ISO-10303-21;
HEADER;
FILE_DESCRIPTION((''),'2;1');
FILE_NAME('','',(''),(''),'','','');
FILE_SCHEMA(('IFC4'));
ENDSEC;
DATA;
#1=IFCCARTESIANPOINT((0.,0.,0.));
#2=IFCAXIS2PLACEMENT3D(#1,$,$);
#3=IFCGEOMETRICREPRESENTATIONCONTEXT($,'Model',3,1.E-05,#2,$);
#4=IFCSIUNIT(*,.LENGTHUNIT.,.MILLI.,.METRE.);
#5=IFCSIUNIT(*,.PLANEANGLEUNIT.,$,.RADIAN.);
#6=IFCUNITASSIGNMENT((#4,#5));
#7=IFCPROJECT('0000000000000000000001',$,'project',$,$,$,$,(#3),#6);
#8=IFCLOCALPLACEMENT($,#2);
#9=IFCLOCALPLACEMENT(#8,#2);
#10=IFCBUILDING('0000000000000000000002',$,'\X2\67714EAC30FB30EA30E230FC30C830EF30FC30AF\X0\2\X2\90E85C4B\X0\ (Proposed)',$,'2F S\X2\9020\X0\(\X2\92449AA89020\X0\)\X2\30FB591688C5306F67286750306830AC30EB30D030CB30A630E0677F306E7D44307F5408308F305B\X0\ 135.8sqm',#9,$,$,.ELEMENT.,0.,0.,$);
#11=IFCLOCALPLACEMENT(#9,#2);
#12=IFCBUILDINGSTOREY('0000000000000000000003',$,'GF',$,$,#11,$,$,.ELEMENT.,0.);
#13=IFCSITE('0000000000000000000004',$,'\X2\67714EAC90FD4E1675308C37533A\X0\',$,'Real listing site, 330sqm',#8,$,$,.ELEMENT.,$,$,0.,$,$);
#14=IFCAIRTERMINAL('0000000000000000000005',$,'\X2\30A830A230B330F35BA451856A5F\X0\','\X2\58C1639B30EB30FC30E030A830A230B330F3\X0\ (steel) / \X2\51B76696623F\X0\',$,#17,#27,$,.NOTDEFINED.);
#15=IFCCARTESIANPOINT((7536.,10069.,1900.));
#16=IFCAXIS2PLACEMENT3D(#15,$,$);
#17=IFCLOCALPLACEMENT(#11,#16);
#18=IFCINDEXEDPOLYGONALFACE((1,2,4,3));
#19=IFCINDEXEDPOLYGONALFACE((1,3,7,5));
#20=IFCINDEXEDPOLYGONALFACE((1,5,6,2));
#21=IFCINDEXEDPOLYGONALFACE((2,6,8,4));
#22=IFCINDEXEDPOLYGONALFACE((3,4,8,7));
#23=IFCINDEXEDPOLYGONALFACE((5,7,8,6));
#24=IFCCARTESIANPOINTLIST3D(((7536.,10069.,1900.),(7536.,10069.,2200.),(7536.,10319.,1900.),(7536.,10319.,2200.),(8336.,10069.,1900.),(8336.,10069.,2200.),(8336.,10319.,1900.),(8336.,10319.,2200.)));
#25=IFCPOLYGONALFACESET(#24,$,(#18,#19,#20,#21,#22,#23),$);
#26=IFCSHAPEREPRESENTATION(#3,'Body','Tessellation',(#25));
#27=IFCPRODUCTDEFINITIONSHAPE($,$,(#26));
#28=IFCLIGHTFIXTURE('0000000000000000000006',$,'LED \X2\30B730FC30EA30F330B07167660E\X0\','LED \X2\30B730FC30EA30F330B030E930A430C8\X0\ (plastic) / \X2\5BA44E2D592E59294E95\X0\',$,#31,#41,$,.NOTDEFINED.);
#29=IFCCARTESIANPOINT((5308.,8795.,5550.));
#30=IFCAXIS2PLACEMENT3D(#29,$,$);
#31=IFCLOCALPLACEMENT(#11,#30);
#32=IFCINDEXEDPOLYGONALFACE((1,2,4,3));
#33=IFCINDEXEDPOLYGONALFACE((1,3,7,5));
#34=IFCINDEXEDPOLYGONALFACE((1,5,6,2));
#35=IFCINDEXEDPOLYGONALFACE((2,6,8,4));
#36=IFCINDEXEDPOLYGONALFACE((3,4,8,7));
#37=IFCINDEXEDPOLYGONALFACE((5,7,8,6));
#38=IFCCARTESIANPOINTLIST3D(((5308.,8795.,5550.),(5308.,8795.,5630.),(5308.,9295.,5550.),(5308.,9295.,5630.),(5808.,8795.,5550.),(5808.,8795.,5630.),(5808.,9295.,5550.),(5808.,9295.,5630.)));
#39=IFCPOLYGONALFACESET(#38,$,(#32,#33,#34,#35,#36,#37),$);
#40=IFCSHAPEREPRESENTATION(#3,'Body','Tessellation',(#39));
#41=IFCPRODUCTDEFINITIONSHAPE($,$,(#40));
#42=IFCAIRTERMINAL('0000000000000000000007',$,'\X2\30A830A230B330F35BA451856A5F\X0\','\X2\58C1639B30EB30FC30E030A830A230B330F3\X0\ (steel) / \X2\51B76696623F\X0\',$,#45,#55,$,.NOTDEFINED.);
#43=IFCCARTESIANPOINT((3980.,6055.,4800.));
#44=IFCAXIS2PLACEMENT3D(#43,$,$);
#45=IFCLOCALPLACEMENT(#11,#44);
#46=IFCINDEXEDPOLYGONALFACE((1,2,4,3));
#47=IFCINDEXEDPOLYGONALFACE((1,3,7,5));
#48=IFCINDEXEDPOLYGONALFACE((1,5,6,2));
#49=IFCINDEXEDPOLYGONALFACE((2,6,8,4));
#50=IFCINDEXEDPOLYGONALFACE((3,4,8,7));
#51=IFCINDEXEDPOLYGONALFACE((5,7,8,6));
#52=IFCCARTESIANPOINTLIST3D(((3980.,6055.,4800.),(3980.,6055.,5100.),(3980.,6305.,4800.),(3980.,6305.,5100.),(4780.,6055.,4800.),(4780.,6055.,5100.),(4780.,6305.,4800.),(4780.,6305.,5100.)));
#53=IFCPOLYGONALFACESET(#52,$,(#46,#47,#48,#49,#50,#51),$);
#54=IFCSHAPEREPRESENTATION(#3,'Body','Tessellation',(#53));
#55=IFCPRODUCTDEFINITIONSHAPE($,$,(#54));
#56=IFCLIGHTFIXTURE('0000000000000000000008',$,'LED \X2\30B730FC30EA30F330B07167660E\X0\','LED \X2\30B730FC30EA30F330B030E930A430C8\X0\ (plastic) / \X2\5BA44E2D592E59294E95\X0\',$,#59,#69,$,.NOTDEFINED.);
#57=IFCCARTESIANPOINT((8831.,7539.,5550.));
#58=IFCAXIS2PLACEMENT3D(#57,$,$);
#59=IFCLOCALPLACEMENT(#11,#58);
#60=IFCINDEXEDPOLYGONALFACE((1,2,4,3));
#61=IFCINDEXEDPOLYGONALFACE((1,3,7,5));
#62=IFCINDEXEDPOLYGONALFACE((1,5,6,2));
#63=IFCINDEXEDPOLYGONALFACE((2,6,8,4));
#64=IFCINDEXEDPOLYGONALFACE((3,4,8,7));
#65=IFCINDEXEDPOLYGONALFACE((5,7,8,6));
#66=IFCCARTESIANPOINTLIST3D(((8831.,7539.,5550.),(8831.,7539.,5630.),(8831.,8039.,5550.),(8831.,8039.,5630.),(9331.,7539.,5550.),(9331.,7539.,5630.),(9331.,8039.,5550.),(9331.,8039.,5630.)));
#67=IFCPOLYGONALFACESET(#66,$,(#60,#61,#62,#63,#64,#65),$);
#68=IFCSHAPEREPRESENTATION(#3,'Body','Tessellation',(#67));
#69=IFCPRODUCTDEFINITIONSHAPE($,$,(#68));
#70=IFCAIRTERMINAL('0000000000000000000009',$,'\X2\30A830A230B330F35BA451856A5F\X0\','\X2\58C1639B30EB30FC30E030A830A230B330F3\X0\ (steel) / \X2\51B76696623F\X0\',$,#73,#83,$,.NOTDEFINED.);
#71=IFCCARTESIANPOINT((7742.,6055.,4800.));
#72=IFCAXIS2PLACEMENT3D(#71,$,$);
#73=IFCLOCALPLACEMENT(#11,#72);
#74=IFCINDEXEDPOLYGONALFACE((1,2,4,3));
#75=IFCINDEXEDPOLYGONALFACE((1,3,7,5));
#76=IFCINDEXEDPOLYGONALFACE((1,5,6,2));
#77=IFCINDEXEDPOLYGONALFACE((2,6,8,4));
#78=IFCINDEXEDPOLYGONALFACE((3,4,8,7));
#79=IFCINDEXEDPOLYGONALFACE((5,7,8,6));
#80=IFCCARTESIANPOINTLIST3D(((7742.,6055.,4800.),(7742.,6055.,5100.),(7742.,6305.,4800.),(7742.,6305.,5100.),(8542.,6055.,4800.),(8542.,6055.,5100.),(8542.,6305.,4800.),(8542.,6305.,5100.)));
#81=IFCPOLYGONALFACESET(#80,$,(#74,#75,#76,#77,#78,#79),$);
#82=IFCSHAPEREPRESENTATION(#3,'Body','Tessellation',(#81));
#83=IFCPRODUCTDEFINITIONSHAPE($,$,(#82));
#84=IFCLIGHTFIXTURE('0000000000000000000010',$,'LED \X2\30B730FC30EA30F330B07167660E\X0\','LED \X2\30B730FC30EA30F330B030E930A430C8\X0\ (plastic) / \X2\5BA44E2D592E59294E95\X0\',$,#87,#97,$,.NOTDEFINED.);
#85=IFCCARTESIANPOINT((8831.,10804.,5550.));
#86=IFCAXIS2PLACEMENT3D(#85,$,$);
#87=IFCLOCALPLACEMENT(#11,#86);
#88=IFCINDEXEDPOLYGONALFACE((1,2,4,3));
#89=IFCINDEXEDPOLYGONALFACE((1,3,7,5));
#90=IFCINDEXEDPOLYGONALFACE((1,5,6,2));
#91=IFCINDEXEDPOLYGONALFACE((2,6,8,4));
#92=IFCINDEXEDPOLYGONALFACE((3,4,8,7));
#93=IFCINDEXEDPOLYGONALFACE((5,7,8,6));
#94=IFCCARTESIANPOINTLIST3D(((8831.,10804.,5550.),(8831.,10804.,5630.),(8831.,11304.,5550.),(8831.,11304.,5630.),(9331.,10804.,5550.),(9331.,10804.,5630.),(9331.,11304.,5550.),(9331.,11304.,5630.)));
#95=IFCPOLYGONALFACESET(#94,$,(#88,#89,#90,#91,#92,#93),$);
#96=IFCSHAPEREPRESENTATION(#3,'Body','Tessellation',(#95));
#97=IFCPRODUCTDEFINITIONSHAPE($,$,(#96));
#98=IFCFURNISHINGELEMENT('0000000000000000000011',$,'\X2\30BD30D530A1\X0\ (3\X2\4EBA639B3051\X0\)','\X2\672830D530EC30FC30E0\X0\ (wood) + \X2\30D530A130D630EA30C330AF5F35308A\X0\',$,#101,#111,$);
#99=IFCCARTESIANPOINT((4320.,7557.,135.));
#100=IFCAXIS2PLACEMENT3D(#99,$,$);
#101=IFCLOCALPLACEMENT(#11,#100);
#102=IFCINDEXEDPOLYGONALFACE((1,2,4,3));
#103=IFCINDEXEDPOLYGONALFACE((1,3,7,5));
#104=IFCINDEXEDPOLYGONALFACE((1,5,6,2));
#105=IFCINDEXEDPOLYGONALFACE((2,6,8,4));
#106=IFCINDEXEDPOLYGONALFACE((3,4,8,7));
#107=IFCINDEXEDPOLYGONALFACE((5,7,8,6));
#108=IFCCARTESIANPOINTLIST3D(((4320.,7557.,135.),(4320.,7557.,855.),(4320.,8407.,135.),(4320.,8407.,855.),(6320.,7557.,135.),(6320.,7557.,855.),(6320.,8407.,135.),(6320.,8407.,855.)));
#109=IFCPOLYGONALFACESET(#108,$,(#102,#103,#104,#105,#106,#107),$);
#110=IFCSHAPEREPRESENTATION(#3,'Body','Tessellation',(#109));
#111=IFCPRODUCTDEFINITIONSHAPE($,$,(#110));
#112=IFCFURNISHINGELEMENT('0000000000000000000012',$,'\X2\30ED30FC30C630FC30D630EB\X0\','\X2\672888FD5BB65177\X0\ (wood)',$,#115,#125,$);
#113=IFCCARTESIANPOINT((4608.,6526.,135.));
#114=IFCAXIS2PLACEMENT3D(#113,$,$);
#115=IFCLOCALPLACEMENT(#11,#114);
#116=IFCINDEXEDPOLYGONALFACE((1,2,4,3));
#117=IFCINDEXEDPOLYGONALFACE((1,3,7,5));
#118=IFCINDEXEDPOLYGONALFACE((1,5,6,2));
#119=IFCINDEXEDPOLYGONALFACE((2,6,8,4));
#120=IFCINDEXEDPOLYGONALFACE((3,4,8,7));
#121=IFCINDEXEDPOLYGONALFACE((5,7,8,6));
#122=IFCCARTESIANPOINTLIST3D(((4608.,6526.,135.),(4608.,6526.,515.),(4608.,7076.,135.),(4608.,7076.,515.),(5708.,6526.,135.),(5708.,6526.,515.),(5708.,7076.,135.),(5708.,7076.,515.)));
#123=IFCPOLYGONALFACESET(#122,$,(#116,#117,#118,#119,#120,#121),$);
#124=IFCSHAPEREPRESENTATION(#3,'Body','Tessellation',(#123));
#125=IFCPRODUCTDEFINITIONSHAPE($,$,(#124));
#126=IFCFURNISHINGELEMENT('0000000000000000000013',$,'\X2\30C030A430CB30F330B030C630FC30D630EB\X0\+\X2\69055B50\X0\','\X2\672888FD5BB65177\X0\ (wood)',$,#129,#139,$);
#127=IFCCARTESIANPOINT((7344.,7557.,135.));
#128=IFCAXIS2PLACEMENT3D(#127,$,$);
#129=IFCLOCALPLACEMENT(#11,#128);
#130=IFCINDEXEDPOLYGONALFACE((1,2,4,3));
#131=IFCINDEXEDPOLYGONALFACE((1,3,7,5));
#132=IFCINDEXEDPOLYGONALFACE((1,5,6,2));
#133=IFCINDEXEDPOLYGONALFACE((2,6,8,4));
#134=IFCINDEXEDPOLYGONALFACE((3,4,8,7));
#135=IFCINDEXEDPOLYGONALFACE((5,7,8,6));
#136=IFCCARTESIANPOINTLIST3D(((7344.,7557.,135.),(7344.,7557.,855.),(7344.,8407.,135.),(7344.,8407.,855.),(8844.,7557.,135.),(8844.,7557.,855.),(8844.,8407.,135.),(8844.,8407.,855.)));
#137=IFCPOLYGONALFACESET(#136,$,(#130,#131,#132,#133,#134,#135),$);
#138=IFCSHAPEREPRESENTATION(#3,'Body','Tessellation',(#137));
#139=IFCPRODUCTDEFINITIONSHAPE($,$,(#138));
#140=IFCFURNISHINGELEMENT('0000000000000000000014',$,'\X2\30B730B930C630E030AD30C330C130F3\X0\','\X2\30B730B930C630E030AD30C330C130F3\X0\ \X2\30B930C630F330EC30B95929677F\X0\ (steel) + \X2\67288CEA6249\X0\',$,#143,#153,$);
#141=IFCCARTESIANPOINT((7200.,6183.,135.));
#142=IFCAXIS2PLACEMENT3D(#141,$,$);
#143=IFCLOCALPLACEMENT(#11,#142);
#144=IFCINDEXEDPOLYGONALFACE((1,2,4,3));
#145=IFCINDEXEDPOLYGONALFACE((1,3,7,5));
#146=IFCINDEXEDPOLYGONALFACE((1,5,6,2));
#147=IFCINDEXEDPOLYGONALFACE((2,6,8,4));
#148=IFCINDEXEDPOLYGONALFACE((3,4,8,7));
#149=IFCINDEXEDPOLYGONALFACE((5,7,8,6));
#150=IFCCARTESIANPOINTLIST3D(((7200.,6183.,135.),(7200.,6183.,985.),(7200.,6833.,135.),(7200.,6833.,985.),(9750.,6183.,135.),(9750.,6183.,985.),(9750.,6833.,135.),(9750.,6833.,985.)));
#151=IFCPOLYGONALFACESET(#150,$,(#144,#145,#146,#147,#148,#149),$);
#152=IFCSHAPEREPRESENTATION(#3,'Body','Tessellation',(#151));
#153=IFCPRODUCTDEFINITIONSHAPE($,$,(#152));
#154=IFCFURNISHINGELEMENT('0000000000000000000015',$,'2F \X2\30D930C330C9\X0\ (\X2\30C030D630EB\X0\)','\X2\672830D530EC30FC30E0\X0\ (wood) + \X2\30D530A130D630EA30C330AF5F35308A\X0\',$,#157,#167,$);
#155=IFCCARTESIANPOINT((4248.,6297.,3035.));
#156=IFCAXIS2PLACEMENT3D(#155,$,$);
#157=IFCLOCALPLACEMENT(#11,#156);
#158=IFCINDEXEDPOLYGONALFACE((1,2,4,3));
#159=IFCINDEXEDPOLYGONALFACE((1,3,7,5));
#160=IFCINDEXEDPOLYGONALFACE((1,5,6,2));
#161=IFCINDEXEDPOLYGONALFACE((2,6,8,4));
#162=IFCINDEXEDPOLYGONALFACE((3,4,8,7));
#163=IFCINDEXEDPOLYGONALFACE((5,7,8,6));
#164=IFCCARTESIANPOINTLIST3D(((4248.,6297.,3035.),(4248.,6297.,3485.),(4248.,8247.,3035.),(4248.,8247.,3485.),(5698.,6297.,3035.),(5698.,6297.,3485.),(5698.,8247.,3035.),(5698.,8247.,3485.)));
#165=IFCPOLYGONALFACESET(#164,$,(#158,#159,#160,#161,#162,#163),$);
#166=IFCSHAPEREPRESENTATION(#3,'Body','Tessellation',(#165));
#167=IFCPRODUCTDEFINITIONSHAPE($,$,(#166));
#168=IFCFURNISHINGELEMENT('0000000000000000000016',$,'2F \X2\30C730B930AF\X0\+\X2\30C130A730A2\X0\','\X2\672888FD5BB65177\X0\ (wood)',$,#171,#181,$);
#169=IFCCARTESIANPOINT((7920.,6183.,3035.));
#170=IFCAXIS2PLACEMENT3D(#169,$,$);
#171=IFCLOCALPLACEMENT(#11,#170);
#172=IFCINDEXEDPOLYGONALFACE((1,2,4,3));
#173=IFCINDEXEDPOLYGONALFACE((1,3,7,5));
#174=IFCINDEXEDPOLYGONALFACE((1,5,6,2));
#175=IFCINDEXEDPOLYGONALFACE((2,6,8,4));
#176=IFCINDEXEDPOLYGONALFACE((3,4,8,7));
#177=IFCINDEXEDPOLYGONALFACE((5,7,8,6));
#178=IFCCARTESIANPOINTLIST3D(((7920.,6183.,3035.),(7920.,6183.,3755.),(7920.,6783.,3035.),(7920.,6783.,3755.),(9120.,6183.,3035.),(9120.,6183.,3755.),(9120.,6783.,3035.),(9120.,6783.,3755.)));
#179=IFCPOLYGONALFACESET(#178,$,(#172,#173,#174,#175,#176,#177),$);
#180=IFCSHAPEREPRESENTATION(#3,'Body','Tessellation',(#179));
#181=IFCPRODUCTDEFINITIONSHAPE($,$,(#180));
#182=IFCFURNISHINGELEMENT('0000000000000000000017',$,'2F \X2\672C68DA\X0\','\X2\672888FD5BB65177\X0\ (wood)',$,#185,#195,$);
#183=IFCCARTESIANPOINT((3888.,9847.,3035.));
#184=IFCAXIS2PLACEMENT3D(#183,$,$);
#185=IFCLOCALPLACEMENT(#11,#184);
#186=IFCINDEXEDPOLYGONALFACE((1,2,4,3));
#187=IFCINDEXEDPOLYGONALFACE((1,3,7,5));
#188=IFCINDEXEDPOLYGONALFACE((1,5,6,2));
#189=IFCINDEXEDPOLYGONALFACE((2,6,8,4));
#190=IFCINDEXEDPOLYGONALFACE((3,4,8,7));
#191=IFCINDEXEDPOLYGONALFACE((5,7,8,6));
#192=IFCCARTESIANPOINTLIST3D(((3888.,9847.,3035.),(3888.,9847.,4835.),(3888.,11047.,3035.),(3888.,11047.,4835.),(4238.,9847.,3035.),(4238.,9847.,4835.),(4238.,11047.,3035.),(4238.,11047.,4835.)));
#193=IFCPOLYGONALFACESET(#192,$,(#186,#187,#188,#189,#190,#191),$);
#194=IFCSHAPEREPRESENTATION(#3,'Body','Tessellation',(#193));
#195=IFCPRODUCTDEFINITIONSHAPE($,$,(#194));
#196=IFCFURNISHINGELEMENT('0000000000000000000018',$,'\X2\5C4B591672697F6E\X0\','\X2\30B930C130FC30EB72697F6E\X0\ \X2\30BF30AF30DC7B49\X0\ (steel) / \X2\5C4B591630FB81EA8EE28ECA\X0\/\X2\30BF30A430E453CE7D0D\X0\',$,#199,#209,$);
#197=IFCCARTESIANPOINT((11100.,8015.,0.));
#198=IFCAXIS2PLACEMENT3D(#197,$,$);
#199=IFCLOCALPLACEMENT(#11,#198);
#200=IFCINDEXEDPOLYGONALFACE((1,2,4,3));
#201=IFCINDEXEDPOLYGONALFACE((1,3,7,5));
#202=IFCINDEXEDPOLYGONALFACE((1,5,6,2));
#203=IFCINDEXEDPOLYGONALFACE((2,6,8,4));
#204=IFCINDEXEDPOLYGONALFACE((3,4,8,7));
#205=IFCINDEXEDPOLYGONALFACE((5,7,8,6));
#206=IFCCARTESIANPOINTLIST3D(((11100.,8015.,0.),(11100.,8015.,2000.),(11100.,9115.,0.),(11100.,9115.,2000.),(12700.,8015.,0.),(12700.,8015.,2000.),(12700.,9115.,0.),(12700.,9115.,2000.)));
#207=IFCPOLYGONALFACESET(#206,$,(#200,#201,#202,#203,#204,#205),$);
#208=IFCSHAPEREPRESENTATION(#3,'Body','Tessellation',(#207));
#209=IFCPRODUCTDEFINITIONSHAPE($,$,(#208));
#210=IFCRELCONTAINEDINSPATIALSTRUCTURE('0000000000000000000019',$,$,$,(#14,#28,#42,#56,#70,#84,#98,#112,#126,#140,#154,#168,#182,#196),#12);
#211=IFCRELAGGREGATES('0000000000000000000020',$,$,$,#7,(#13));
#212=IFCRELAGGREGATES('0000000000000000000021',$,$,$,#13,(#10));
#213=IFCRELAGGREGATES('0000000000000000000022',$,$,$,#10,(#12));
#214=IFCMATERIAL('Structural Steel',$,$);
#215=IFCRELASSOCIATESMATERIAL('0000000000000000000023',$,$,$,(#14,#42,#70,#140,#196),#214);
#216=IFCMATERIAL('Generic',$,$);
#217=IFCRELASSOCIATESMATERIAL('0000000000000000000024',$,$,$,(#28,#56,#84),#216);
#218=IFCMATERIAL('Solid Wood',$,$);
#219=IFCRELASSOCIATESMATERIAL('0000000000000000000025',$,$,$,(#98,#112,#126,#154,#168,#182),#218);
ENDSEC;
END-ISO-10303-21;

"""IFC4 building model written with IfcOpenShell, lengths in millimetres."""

from ifc_helpers import new_model, si_unit, frame, frame_2d, origin, place, context, project, spatial, rectangle, extrude, material, element, save


model = new_model("IFC4")

# Units and contexts
model_context = context("Model", 3, precision=1e-05, world=origin())
ifc_project = project(units=[si_unit("LENGTHUNIT", "METRE", prefix="MILLI"), si_unit("PLANEANGLEUNIT", "RADIAN")], contexts=[model_context])

# Site, building, storey
site_placement = place(None, origin())
site = spatial("IfcSite", under=ifc_project, at=site_placement, Name="東京都世田谷区", ObjectType="Real listing site, 330sqm", CompositionType="ELEMENT", RefElevation=0.0)
building_placement = place(site_placement, origin())
building = spatial("IfcBuilding", under=site, at=building_placement, Name="東京・リモートワーク2部屋 (Proposed)", ObjectType="2F S造(鉄骨造)・外装は木材とガルバニウム板の組み合わせ 135.8sqm", CompositionType="ELEMENT", ElevationOfRefHeight=0.0, ElevationOfTerrain=0.0)
storey_placement = place(building_placement, origin())
storey = spatial("IfcBuildingStorey", under=building, at=storey_placement, Name="GF", CompositionType="ELEMENT", Elevation=0.0)

# Shared definitions
ifc_material_1 = material(Name="Solid Wood")

# Shared definitions
ifc_material_2 = material(Name="Structural Steel")

# Shared definitions
ifc_material_3 = material(Name="Generic")

# Air terminal
air_terminal_1_placement = place(storey_placement, frame((7536.0, 10069.0, 1900.0)))
element("IfcAirTerminal", 1, at=air_terminal_1_placement, inside=storey, material=ifc_material_2, Name="エアコン室内機", Description="壁掛ルームエアコン (steel) / 冷暖房", PredefinedType="NOTDEFINED", context=model_context, shape_type="SweptSolid", body=[
    extrude(rectangle(XDim=800.0, YDim=250.0, at=frame_2d((400.0, 125.0))), frame((7536.0, 10069.0, 1900.0)), (0.0, 0.0, 1.0), 300.0),
])

# Light fixture
light_fixture_1_placement = place(storey_placement, frame((5308.0, 8795.0, 5550.0)))
element("IfcLightFixture", 2, at=light_fixture_1_placement, inside=storey, material=ifc_material_3, Name="LED シーリング照明", Description="LED シーリングライト (plastic) / 室中央天井", PredefinedType="NOTDEFINED", context=model_context, shape_type="SweptSolid", body=[
    extrude(rectangle(XDim=500.0, YDim=500.0, at=frame_2d((250.0, 250.0))), frame((5308.0, 8795.0, 5550.0)), (0.0, 0.0, 1.0), 80.0),
])

# Air terminal
air_terminal_2_placement = place(storey_placement, frame((3980.0, 6055.0, 4800.0)))
element("IfcAirTerminal", 3, at=air_terminal_2_placement, inside=storey, material=ifc_material_2, Name="エアコン室内機", Description="壁掛ルームエアコン (steel) / 冷暖房", PredefinedType="NOTDEFINED", context=model_context, shape_type="SweptSolid", body=[
    extrude(rectangle(XDim=800.0, YDim=250.0, at=frame_2d((400.0, 125.0))), frame((3980.0, 6055.0, 4800.0)), (0.0, 0.0, 1.0), 300.0),
])

# Light fixture
light_fixture_2_placement = place(storey_placement, frame((8831.0, 7539.0, 5550.0)))
element("IfcLightFixture", 4, at=light_fixture_2_placement, inside=storey, material=ifc_material_3, Name="LED シーリング照明", Description="LED シーリングライト (plastic) / 室中央天井", PredefinedType="NOTDEFINED", context=model_context, shape_type="SweptSolid", body=[
    extrude(rectangle(XDim=500.0, YDim=500.0, at=frame_2d((250.0, 250.0))), frame((8831.0, 7539.0, 5550.0)), (0.0, 0.0, 1.0), 80.0),
])

# Air terminal
air_terminal_3_placement = place(storey_placement, frame((7742.0, 6055.0, 4800.0)))
element("IfcAirTerminal", 5, at=air_terminal_3_placement, inside=storey, material=ifc_material_2, Name="エアコン室内機", Description="壁掛ルームエアコン (steel) / 冷暖房", PredefinedType="NOTDEFINED", context=model_context, shape_type="SweptSolid", body=[
    extrude(rectangle(XDim=800.0, YDim=250.0, at=frame_2d((400.0, 125.0))), frame((7742.0, 6055.0, 4800.0)), (0.0, 0.0, 1.0), 300.0),
])

# Light fixture
light_fixture_3_placement = place(storey_placement, frame((8831.0, 10804.0, 5550.0)))
element("IfcLightFixture", 6, at=light_fixture_3_placement, inside=storey, material=ifc_material_3, Name="LED シーリング照明", Description="LED シーリングライト (plastic) / 室中央天井", PredefinedType="NOTDEFINED", context=model_context, shape_type="SweptSolid", body=[
    extrude(rectangle(XDim=500.0, YDim=500.0, at=frame_2d((250.0, 250.0))), frame((8831.0, 10804.0, 5550.0)), (0.0, 0.0, 1.0), 80.0),
])

# Furnishing elements
furnishing_1_placement = place(storey_placement, frame((4320.0, 7557.0, 135.0)))
element("IfcFurnishingElement", 7, at=furnishing_1_placement, inside=storey, material=ifc_material_1, Name="ソファ (3人掛け)", Description="木フレーム (wood) + ファブリック張り", context=model_context, shape_type="SweptSolid", body=[
    extrude(rectangle(XDim=2000.0, YDim=850.0, at=frame_2d((1000.0, 425.0))), frame((4320.0, 7557.0, 135.0)), (0.0, 0.0, 1.0), 720.0),
])
furnishing_2_placement = place(storey_placement, frame((4608.0, 6526.0, 135.0)))
element("IfcFurnishingElement", 8, at=furnishing_2_placement, inside=storey, material=ifc_material_1, Name="ローテーブル", Description="木製家具 (wood)", context=model_context, shape_type="SweptSolid", body=[
    extrude(rectangle(XDim=1100.0, YDim=550.0, at=frame_2d((550.0, 275.0))), frame((4608.0, 6526.0, 135.0)), (0.0, 0.0, 1.0), 380.0),
])
furnishing_3_placement = place(storey_placement, frame((7344.0, 7557.0, 135.0)))
element("IfcFurnishingElement", 9, at=furnishing_3_placement, inside=storey, material=ifc_material_1, Name="ダイニングテーブル+椅子", Description="木製家具 (wood)", context=model_context, shape_type="SweptSolid", body=[
    extrude(rectangle(XDim=1500.0, YDim=850.0, at=frame_2d((750.0, 425.0))), frame((7344.0, 7557.0, 135.0)), (0.0, 0.0, 1.0), 720.0),
])
furnishing_4_placement = place(storey_placement, frame((7200.0, 6183.0, 135.0)))
element("IfcFurnishingElement", 10, at=furnishing_4_placement, inside=storey, material=ifc_material_2, Name="システムキッチン", Description="システムキッチン ステンレス天板 (steel) + 木質扉", context=model_context, shape_type="SweptSolid", body=[
    extrude(rectangle(XDim=2550.0, YDim=650.0, at=frame_2d((1275.0, 325.0))), frame((7200.0, 6183.0, 135.0)), (0.0, 0.0, 1.0), 850.0),
])
furnishing_5_placement = place(storey_placement, frame((4248.0, 6297.0, 3035.0)))
element("IfcFurnishingElement", 11, at=furnishing_5_placement, inside=storey, material=ifc_material_1, Name="2F ベッド (ダブル)", Description="木フレーム (wood) + ファブリック張り", context=model_context, shape_type="SweptSolid", body=[
    extrude(rectangle(XDim=1450.0, YDim=1950.0, at=frame_2d((725.0, 975.0))), frame((4248.0, 6297.0, 3035.0)), (0.0, 0.0, 1.0), 450.0),
])
furnishing_6_placement = place(storey_placement, frame((7920.0, 6183.0, 3035.0)))
element("IfcFurnishingElement", 12, at=furnishing_6_placement, inside=storey, material=ifc_material_1, Name="2F デスク+チェア", Description="木製家具 (wood)", context=model_context, shape_type="SweptSolid", body=[
    extrude(rectangle(XDim=1200.0, YDim=600.0, at=frame_2d((600.0, 300.0))), frame((7920.0, 6183.0, 3035.0)), (0.0, 0.0, 1.0), 720.0),
])
furnishing_7_placement = place(storey_placement, frame((3888.0, 9847.0, 3035.0)))
element("IfcFurnishingElement", 13, at=furnishing_7_placement, inside=storey, material=ifc_material_1, Name="2F 本棚", Description="木製家具 (wood)", context=model_context, shape_type="SweptSolid", body=[
    extrude(rectangle(XDim=350.0, YDim=1200.0, at=frame_2d((175.0, 600.0))), frame((3888.0, 9847.0, 3035.0)), (0.0, 0.0, 1.0), 1800.0),
])
furnishing_8_placement = place(storey_placement, frame((11100.0, 8015.0, 0.0)))
element("IfcFurnishingElement", 14, at=furnishing_8_placement, inside=storey, material=ifc_material_2, Name="屋外物置", Description="スチール物置 タクボ等 (steel) / 屋外・自転車/タイヤ収納", context=model_context, shape_type="SweptSolid", body=[
    extrude(rectangle(XDim=1600.0, YDim=1100.0, at=frame_2d((800.0, 550.0))), frame((11100.0, 8015.0, 0.0)), (0.0, 0.0, 1.0), 2000.0),
])

save(model, "model.ifc")
